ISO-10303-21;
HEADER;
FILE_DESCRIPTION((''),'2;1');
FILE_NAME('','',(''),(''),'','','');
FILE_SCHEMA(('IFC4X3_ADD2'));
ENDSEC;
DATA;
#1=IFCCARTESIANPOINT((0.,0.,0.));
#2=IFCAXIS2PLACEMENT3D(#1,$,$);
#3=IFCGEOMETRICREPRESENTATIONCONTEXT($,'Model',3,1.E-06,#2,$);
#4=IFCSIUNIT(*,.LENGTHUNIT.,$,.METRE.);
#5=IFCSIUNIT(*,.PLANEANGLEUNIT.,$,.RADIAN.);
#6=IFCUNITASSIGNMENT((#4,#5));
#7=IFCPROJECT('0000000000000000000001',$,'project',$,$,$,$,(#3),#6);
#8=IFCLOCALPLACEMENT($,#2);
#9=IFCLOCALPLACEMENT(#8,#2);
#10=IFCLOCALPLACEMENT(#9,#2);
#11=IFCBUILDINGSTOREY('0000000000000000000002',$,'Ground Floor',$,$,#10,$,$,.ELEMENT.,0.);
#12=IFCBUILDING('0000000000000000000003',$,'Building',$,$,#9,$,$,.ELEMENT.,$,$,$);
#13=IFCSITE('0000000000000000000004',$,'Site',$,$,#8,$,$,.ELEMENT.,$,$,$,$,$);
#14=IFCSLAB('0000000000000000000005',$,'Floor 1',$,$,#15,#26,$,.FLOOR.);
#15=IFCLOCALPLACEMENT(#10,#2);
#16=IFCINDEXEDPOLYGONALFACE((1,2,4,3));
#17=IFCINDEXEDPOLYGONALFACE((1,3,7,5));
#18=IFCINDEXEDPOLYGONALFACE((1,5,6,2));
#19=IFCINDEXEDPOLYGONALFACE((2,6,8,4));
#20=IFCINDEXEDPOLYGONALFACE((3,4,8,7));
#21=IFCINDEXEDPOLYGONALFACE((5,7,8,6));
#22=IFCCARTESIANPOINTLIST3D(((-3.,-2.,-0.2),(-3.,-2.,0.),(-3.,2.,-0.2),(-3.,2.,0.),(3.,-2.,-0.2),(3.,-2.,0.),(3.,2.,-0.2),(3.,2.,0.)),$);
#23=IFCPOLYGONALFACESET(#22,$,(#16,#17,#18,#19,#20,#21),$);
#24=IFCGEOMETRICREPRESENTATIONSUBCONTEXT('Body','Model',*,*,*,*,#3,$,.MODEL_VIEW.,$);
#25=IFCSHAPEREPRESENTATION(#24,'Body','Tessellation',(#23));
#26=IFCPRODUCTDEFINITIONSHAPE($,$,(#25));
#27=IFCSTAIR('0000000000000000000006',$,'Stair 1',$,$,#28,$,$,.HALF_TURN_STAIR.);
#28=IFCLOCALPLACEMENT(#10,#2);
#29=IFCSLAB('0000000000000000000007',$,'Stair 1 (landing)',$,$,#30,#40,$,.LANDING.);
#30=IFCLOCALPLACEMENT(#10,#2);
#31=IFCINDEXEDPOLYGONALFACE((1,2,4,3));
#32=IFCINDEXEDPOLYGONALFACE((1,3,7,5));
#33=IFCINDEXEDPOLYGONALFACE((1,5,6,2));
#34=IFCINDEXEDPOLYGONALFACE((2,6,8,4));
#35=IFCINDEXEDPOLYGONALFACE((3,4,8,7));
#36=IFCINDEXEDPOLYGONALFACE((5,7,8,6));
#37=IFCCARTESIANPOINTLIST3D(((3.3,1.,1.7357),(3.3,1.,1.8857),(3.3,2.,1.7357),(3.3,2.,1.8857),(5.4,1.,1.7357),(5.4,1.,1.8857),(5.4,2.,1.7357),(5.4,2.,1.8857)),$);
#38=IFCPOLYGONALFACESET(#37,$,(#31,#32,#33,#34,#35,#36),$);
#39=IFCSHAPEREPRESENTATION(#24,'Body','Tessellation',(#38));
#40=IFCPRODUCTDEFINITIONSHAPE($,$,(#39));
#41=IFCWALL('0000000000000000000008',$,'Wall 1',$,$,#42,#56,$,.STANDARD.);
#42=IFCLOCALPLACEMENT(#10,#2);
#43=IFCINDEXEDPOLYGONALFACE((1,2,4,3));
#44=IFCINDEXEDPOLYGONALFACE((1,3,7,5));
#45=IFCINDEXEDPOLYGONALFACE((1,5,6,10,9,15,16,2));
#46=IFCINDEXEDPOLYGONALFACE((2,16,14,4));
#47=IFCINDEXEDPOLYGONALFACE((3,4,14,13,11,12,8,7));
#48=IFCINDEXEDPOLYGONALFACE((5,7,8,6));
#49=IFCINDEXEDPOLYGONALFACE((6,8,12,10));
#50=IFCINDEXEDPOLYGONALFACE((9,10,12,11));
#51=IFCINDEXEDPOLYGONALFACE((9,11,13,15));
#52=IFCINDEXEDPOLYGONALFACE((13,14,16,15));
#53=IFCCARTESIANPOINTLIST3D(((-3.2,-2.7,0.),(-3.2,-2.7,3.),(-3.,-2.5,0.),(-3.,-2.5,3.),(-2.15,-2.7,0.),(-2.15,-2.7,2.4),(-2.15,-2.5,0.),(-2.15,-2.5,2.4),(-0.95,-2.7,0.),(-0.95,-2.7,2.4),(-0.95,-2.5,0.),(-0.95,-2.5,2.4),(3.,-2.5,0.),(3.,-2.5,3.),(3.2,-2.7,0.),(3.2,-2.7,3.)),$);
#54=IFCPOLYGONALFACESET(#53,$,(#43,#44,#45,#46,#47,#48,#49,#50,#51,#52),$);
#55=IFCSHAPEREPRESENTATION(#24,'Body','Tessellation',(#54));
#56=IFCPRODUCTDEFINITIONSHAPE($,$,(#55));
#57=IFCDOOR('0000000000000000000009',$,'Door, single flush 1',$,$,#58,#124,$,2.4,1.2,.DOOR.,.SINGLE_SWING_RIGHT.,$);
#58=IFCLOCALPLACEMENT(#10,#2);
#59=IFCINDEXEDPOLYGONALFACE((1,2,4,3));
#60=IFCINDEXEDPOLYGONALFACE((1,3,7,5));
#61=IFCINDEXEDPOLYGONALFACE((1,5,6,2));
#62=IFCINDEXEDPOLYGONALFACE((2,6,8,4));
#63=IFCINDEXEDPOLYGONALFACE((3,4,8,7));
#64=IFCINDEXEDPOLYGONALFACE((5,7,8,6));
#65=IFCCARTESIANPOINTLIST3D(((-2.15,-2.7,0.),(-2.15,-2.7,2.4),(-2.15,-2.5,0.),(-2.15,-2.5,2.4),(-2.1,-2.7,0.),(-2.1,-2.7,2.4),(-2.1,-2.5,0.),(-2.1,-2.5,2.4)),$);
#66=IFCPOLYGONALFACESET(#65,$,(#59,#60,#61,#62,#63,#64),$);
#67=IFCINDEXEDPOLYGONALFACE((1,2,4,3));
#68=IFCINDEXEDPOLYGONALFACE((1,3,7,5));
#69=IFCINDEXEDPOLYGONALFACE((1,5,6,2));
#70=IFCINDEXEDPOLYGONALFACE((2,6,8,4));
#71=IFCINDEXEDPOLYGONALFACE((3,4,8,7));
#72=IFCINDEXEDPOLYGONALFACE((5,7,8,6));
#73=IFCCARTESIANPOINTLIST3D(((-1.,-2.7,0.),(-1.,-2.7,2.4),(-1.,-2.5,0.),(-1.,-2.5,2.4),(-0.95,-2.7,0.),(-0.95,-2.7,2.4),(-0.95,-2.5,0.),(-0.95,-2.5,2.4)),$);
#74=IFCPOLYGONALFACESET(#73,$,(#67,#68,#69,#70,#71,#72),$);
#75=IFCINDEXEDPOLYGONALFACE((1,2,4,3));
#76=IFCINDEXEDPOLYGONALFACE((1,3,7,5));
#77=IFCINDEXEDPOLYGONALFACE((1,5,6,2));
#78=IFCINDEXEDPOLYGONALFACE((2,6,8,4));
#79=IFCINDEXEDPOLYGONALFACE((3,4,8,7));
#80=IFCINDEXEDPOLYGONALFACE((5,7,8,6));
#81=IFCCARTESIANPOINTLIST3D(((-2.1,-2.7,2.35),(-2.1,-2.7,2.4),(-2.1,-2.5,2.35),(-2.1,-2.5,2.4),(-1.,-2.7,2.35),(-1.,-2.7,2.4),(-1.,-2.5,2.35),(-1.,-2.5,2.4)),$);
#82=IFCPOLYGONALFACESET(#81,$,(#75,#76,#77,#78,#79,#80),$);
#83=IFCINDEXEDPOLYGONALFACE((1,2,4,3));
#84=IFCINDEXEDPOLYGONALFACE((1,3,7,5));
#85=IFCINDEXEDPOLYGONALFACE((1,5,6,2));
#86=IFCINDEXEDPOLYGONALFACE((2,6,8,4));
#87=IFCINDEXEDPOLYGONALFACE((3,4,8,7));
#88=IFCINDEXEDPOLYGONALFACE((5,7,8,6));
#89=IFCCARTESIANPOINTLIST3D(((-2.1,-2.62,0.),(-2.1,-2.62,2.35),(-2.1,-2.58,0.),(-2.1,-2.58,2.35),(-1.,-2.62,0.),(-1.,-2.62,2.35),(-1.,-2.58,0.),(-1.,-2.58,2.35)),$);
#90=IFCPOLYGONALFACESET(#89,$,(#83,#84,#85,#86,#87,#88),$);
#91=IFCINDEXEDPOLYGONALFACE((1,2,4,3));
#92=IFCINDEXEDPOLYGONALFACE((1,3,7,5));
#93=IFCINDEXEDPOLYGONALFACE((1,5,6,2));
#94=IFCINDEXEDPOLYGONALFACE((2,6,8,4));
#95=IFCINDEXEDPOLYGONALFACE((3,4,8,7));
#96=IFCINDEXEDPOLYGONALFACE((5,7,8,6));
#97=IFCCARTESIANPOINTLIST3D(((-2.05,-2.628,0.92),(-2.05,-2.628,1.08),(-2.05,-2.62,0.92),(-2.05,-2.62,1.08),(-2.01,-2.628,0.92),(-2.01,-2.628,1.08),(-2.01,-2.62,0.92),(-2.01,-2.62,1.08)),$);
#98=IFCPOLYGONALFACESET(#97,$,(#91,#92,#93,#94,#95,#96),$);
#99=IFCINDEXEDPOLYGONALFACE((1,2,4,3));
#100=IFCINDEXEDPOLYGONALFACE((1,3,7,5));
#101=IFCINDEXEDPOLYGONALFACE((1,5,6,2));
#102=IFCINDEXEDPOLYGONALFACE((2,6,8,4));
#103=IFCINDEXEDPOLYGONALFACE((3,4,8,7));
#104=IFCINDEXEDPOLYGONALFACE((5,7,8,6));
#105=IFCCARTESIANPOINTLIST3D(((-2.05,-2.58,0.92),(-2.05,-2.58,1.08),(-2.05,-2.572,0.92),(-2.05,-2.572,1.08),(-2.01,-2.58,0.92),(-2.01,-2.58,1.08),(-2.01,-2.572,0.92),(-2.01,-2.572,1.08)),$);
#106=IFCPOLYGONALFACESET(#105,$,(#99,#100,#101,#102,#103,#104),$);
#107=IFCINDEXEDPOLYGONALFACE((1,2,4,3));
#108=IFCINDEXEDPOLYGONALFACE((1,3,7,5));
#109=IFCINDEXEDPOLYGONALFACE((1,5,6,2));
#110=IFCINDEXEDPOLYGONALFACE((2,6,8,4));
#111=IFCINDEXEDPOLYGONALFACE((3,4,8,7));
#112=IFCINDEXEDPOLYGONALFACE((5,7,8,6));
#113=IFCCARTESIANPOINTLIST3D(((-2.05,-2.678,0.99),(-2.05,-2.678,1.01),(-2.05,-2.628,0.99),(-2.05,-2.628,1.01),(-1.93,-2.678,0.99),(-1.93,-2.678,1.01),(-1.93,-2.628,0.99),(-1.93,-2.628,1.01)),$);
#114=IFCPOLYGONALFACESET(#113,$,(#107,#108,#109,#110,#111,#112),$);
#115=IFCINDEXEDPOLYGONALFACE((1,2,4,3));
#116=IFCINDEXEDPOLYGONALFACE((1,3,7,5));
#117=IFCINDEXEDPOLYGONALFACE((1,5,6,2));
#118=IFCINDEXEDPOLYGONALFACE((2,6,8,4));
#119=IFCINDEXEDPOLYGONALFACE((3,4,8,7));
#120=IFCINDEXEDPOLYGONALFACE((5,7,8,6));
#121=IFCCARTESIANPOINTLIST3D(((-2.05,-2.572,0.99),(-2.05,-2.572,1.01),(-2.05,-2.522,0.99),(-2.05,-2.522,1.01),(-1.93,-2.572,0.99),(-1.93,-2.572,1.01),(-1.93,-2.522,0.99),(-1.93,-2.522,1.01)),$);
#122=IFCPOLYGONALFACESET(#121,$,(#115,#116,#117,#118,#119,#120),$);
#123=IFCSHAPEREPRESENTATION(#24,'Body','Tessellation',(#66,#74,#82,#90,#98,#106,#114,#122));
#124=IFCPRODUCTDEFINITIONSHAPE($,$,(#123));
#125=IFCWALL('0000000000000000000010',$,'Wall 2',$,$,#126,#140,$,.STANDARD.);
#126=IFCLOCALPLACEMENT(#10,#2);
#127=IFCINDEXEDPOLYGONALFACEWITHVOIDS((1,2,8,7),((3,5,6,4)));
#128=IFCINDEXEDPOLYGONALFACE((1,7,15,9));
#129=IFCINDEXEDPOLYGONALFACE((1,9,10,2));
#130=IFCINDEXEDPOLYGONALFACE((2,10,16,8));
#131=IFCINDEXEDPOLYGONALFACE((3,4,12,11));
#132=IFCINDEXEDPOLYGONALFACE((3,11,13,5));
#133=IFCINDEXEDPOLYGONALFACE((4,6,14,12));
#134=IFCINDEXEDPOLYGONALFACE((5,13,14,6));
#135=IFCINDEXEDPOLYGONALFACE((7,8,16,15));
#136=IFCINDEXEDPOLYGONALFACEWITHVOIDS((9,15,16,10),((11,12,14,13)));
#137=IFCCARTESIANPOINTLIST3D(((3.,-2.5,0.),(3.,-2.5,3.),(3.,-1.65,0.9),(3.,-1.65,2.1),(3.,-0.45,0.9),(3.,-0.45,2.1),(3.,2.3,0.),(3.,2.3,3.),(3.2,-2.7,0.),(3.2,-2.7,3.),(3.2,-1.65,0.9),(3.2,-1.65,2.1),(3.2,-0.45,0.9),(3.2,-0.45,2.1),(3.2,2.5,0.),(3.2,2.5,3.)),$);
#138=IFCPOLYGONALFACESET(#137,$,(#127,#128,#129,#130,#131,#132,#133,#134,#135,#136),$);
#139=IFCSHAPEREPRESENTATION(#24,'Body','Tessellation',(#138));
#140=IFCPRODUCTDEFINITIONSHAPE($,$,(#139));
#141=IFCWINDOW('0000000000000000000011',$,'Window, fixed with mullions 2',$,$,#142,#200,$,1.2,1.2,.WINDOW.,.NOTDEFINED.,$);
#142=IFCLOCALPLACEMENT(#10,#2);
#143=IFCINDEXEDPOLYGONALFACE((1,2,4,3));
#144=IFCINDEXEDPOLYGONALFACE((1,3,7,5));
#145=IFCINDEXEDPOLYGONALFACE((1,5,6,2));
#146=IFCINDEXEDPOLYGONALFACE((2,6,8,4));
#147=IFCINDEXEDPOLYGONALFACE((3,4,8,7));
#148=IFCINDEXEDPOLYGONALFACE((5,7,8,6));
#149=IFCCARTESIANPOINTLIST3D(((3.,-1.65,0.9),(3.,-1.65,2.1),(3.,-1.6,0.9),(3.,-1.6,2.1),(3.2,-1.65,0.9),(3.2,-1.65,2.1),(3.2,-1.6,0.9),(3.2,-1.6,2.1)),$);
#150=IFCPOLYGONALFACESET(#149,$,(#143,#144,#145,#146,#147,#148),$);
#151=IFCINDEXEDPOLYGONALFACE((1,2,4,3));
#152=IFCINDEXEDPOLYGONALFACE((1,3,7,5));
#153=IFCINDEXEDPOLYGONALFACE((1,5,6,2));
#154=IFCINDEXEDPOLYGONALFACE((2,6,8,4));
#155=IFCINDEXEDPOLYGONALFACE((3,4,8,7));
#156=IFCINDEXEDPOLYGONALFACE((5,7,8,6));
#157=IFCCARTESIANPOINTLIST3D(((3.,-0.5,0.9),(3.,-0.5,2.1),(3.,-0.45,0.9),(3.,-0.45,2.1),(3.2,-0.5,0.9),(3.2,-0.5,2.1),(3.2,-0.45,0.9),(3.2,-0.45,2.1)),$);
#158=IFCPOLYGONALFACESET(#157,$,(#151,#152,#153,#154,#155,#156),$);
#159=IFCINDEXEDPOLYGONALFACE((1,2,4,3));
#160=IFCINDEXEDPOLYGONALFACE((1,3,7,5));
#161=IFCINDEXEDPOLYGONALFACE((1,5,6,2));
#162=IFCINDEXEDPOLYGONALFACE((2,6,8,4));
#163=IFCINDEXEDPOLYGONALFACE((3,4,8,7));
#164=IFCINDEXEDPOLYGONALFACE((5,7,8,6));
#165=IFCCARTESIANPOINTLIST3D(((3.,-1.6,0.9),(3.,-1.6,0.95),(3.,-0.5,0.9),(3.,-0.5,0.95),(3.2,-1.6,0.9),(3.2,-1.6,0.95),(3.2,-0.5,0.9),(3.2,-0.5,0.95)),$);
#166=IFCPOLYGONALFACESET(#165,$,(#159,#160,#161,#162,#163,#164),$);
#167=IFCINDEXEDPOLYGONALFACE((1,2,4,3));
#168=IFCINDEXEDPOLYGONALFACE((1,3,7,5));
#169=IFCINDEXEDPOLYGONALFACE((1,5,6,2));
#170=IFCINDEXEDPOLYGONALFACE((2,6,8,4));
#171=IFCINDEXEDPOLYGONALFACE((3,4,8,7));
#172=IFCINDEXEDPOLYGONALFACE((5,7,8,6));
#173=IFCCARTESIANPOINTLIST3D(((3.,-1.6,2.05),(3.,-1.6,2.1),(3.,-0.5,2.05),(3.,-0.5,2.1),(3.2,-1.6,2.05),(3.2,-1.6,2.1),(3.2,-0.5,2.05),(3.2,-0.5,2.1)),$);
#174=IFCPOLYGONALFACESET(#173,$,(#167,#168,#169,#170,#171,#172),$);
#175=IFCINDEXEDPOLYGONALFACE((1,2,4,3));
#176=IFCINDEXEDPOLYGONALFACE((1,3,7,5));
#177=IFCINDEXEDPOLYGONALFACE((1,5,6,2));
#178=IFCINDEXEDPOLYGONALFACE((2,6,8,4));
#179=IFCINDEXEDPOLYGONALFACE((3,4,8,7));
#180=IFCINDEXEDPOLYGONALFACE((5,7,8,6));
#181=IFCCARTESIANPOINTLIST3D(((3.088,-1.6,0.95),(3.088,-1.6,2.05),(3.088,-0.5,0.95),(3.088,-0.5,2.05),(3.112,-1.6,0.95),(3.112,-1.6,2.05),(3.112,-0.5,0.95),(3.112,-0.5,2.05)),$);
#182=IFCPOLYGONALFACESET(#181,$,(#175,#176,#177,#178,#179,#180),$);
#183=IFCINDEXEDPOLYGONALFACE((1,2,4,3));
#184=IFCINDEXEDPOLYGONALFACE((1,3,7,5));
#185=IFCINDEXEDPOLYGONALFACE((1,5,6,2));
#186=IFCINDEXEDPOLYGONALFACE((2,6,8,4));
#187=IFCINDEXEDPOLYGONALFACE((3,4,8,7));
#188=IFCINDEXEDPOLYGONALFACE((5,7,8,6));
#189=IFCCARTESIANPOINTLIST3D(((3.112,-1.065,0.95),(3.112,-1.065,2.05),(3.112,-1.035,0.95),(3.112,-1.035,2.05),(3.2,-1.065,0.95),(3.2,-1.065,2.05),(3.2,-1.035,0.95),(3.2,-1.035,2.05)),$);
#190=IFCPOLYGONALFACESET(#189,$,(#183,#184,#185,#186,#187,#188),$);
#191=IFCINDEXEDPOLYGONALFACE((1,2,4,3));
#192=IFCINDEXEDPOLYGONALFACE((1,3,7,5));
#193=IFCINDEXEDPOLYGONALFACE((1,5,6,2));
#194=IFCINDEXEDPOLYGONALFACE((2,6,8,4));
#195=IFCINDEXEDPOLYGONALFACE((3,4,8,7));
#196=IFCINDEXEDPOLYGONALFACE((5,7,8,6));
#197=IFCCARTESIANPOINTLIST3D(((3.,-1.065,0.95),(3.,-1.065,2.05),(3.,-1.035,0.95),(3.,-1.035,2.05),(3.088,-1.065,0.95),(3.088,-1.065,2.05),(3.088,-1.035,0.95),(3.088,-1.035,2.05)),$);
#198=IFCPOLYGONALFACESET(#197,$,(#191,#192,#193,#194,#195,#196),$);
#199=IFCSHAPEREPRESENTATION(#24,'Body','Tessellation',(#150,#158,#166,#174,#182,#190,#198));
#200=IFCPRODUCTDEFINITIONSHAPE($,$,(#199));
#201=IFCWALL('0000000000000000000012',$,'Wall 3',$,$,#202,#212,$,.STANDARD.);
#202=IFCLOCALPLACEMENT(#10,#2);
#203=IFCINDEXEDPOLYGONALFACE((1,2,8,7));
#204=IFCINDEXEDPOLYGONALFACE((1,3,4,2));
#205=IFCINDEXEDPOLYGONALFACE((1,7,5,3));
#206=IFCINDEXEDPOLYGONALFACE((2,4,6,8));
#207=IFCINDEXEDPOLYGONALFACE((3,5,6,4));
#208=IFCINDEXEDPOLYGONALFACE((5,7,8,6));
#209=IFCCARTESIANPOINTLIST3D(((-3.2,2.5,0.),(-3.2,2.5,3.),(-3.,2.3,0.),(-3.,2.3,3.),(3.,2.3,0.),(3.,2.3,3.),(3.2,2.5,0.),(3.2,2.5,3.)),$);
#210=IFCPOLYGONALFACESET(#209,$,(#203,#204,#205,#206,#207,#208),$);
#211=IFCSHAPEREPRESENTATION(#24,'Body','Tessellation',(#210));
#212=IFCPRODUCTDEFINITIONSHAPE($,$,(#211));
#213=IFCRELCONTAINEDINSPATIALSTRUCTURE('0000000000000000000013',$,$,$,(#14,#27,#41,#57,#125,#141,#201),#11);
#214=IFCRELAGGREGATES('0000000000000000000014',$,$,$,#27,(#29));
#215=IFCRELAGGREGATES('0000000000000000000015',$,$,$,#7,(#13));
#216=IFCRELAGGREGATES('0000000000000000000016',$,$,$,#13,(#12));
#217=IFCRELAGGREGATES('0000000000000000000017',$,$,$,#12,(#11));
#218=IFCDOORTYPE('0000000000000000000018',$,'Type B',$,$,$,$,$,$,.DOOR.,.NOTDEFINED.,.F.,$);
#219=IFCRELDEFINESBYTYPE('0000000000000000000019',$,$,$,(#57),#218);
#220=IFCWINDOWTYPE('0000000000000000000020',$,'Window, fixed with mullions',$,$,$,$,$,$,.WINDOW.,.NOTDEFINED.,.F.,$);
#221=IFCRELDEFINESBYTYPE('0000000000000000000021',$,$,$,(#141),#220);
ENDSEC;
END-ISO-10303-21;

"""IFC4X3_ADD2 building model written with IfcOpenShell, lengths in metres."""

from ifc_helpers import new_model, si_unit, frame, frame_2d, origin, origin_with_axes, origin_2d, origin_2d_with_axis, place, context, subcontext, project, spatial, polyline, rectangle, outline, extrude, source, transform, mapped, type_object, type_shapes, element, fill, aggregate, save


model = new_model("IFC4X3_ADD2")

# Units and contexts
model_context = context("Model", 3, precision=1e-06, world=origin())
body_context = subcontext(model_context, "Body", "Model", "MODEL_VIEW")
ifc_project = project(units=[si_unit("LENGTHUNIT", "METRE"), si_unit("PLANEANGLEUNIT", "RADIAN")], contexts=[model_context])

# Site, building, storey
site_placement = place(None, origin())
site = spatial("IfcSite", under=ifc_project, at=site_placement, Name="Site", CompositionType="ELEMENT")
building_placement = place(site_placement, origin())
building = spatial("IfcBuilding", under=site, at=building_placement, Name="Building", CompositionType="ELEMENT")
storey_placement = place(building_placement, origin())
storey = spatial("IfcBuildingStorey", under=building, at=storey_placement, Name="Ground Floor", CompositionType="ELEMENT", Elevation=0.0)

# Slab
slab_1_placement = place(storey_placement, origin())
element("IfcSlab", 1, at=slab_1_placement, inside=storey, Name="Floor 1", PredefinedType="FLOOR", context=body_context, shape_type="SweptSolid", body=[
    extrude(outline(polyline([(-3.0, -2.0), (3.0, -2.0), (3.0, 2.0), (-3.0, 2.0), (-3.0, -2.0)])), frame((0.0, 0.0, -0.2)), (0.0, 0.0, 1.0), 0.2),
])

# Stair, slab
stair_placement = place(storey_placement, origin())
stair = element("IfcStair", 2, at=stair_placement, inside=storey, Name="Stair 1", PredefinedType="HALF_TURN_STAIR")
slab_2_placement = place(storey_placement, origin())
slab_2 = element("IfcSlab", 3, at=slab_2_placement, Name="Stair 1 (landing)", PredefinedType="LANDING", context=body_context, shape_type="SweptSolid", body=[
    extrude(outline(polyline([(5.4, 1.0), (5.4, 2.0), (3.3, 2.0), (3.3, 1.0), (5.4, 1.0)])), frame((0.0, 0.0, 1.7357)), (0.0, 0.0, 1.0), 0.15),
])

# Wall, opening, door
wall_1_placement = place(storey_placement, origin())
wall_1 = element("IfcWall", 4, at=wall_1_placement, inside=storey, Name="Wall 1", PredefinedType="STANDARD", context=body_context, shape_type="SweptSolid", body=[
    extrude(outline(polyline([(-3.0, -2.5), (3.0, -2.5), (3.2, -2.7), (-3.2, -2.7), (-3.0, -2.5)])), origin(), (0.0, 0.0, 1.0), 3.0),
])
opening_1_placement = place(wall_1_placement, frame((-1.55, -2.45, 1.2), z_axis=(0.0, -1.0, 0.0), x_axis=(1.0, 0.0, 0.0)))
opening_1 = element("IfcOpeningElement", 5, at=opening_1_placement, cuts=wall_1, PredefinedType="OPENING", context=body_context, shape_type="SweptSolid", body=[
    extrude(rectangle(XDim=1.2, YDim=2.4, at=origin_2d()), origin_with_axes(), (0.0, 0.0, 1.0), 0.3),
])
door_type = type_object("IfcDoorType", Name="Type B", OperationType="NOTDEFINED", ParameterTakesPrecedence=False, PredefinedType="DOOR")
shared_shape_1 = source(origin(), body_context, "Body", "SweptSolid", [
    extrude(rectangle(XDim=0.05, YDim=0.2, at=frame_2d((-0.575, 0.0), x_axis=(1.0, 0.0))), origin(), (0.0, 0.0, 1.0), 2.4),
    extrude(rectangle(XDim=0.05, YDim=0.2, at=frame_2d((0.575, 0.0), x_axis=(1.0, 0.0))), origin(), (0.0, 0.0, 1.0), 2.4),
    extrude(rectangle(XDim=1.1, YDim=0.2, at=origin_2d_with_axis()), frame((0.0, 0.0, 2.35)), (0.0, 0.0, 1.0), 0.05),
    extrude(rectangle(XDim=1.1, YDim=0.04, at=origin_2d_with_axis()), origin(), (0.0, 0.0, 1.0), 2.35),
    extrude(rectangle(XDim=0.04, YDim=0.008, at=frame_2d((-0.48, -0.024), x_axis=(1.0, 0.0))), frame((0.0, 0.0, 0.92)), (0.0, 0.0, 1.0), 0.16),
    extrude(rectangle(XDim=0.04, YDim=0.008, at=frame_2d((-0.48, 0.024), x_axis=(1.0, 0.0))), frame((0.0, 0.0, 0.92)), (0.0, 0.0, 1.0), 0.16),
    extrude(rectangle(XDim=0.12, YDim=0.05, at=frame_2d((-0.44, -0.053), x_axis=(1.0, 0.0))), frame((0.0, 0.0, 0.99)), (0.0, 0.0, 1.0), 0.02),
    extrude(rectangle(XDim=0.12, YDim=0.05, at=frame_2d((-0.44, 0.053), x_axis=(1.0, 0.0))), frame((0.0, 0.0, 0.99)), (0.0, 0.0, 1.0), 0.02),
])
type_shapes(door_type, [shared_shape_1])
door_placement = place(storey_placement, frame((-1.55, -2.6, 0.0), z_axis=(0.0, 0.0, 1.0), x_axis=(1.0, 0.0, 0.0)))
door = element("IfcDoor", 6, at=door_placement, inside=storey, type_object=door_type, Name="Door, single flush 1", OperationType="SINGLE_SWING_RIGHT", OverallHeight=2.4, OverallWidth=1.2, PredefinedType="DOOR", context=body_context, shape_type="MappedRepresentation", body=[
    mapped(shared_shape_1, transform((0.0, 0.0, 0.0), scale=1.0)),
])
fill(opening_1, door)

# Wall, opening, window
wall_2_placement = place(storey_placement, origin())
wall_2 = element("IfcWall", 7, at=wall_2_placement, inside=storey, Name="Wall 2", PredefinedType="STANDARD", context=body_context, shape_type="SweptSolid", body=[
    extrude(outline(polyline([(3.0, -2.5), (3.0, 2.3), (3.2, 2.5), (3.2, -2.7), (3.0, -2.5)])), origin(), (0.0, 0.0, 1.0), 3.0),
])
opening_2_placement = place(wall_2_placement, frame((2.95, -1.05, 1.5), z_axis=(1.0, 0.0, 0.0), x_axis=(0.0, 1.0, 0.0)))
opening_2 = element("IfcOpeningElement", 8, at=opening_2_placement, cuts=wall_2, PredefinedType="OPENING", context=body_context, shape_type="SweptSolid", body=[
    extrude(rectangle(XDim=1.2, YDim=1.2, at=origin_2d()), origin_with_axes(), (0.0, 0.0, 1.0), 0.3),
])
window_type = type_object("IfcWindowType", Name="Window, fixed with mullions", ParameterTakesPrecedence=False, PartitioningType="NOTDEFINED", PredefinedType="WINDOW")
shared_shape_2 = source(origin(), body_context, "Body", "SweptSolid", [
    extrude(rectangle(XDim=0.05, YDim=0.2, at=frame_2d((-0.575, 0.0), x_axis=(1.0, 0.0))), frame((0.0, 0.0, 0.9)), (0.0, 0.0, 1.0), 1.2),
    extrude(rectangle(XDim=0.05, YDim=0.2, at=frame_2d((0.575, 0.0), x_axis=(1.0, 0.0))), frame((0.0, 0.0, 0.9)), (0.0, 0.0, 1.0), 1.2),
    extrude(rectangle(XDim=1.1, YDim=0.2, at=origin_2d_with_axis()), frame((0.0, 0.0, 0.9)), (0.0, 0.0, 1.0), 0.05),
    extrude(rectangle(XDim=1.1, YDim=0.2, at=origin_2d_with_axis()), frame((0.0, 0.0, 2.05)), (0.0, 0.0, 1.0), 0.05),
    extrude(rectangle(XDim=1.1, YDim=0.024, at=origin_2d_with_axis()), frame((0.0, 0.0, 0.95)), (0.0, 0.0, 1.0), 1.1),
    extrude(rectangle(XDim=0.03, YDim=0.088, at=frame_2d((0.0, -0.056), x_axis=(1.0, 0.0))), frame((0.0, 0.0, 0.95)), (0.0, 0.0, 1.0), 1.1),
    extrude(rectangle(XDim=0.03, YDim=0.088, at=frame_2d((0.0, 0.056), x_axis=(1.0, 0.0))), frame((0.0, 0.0, 0.95)), (0.0, 0.0, 1.0), 1.1),
])
type_shapes(window_type, [shared_shape_2])
window_placement = place(storey_placement, frame((3.1, -1.05, 0.0), z_axis=(0.0, 0.0, 1.0), x_axis=(0.0, 1.0, 0.0)))
window = element("IfcWindow", 9, at=window_placement, inside=storey, type_object=window_type, Name="Window, fixed with mullions 2", OverallHeight=1.2, OverallWidth=1.2, PartitioningType="NOTDEFINED", PredefinedType="WINDOW", context=body_context, shape_type="MappedRepresentation", body=[
    mapped(shared_shape_2, transform((0.0, 0.0, 0.0), scale=1.0)),
])
fill(opening_2, window)

# Wall
wall_3_placement = place(storey_placement, origin())
element("IfcWall", 10, at=wall_3_placement, inside=storey, Name="Wall 3", PredefinedType="STANDARD", context=body_context, shape_type="SweptSolid", body=[
    extrude(outline(polyline([(3.0, 2.3), (-3.0, 2.3), (-3.2, 2.5), (3.2, 2.5), (3.0, 2.3)])), origin(), (0.0, 0.0, 1.0), 3.0),
])

aggregate(stair, [slab_2])

save(model, "model.ifc")
